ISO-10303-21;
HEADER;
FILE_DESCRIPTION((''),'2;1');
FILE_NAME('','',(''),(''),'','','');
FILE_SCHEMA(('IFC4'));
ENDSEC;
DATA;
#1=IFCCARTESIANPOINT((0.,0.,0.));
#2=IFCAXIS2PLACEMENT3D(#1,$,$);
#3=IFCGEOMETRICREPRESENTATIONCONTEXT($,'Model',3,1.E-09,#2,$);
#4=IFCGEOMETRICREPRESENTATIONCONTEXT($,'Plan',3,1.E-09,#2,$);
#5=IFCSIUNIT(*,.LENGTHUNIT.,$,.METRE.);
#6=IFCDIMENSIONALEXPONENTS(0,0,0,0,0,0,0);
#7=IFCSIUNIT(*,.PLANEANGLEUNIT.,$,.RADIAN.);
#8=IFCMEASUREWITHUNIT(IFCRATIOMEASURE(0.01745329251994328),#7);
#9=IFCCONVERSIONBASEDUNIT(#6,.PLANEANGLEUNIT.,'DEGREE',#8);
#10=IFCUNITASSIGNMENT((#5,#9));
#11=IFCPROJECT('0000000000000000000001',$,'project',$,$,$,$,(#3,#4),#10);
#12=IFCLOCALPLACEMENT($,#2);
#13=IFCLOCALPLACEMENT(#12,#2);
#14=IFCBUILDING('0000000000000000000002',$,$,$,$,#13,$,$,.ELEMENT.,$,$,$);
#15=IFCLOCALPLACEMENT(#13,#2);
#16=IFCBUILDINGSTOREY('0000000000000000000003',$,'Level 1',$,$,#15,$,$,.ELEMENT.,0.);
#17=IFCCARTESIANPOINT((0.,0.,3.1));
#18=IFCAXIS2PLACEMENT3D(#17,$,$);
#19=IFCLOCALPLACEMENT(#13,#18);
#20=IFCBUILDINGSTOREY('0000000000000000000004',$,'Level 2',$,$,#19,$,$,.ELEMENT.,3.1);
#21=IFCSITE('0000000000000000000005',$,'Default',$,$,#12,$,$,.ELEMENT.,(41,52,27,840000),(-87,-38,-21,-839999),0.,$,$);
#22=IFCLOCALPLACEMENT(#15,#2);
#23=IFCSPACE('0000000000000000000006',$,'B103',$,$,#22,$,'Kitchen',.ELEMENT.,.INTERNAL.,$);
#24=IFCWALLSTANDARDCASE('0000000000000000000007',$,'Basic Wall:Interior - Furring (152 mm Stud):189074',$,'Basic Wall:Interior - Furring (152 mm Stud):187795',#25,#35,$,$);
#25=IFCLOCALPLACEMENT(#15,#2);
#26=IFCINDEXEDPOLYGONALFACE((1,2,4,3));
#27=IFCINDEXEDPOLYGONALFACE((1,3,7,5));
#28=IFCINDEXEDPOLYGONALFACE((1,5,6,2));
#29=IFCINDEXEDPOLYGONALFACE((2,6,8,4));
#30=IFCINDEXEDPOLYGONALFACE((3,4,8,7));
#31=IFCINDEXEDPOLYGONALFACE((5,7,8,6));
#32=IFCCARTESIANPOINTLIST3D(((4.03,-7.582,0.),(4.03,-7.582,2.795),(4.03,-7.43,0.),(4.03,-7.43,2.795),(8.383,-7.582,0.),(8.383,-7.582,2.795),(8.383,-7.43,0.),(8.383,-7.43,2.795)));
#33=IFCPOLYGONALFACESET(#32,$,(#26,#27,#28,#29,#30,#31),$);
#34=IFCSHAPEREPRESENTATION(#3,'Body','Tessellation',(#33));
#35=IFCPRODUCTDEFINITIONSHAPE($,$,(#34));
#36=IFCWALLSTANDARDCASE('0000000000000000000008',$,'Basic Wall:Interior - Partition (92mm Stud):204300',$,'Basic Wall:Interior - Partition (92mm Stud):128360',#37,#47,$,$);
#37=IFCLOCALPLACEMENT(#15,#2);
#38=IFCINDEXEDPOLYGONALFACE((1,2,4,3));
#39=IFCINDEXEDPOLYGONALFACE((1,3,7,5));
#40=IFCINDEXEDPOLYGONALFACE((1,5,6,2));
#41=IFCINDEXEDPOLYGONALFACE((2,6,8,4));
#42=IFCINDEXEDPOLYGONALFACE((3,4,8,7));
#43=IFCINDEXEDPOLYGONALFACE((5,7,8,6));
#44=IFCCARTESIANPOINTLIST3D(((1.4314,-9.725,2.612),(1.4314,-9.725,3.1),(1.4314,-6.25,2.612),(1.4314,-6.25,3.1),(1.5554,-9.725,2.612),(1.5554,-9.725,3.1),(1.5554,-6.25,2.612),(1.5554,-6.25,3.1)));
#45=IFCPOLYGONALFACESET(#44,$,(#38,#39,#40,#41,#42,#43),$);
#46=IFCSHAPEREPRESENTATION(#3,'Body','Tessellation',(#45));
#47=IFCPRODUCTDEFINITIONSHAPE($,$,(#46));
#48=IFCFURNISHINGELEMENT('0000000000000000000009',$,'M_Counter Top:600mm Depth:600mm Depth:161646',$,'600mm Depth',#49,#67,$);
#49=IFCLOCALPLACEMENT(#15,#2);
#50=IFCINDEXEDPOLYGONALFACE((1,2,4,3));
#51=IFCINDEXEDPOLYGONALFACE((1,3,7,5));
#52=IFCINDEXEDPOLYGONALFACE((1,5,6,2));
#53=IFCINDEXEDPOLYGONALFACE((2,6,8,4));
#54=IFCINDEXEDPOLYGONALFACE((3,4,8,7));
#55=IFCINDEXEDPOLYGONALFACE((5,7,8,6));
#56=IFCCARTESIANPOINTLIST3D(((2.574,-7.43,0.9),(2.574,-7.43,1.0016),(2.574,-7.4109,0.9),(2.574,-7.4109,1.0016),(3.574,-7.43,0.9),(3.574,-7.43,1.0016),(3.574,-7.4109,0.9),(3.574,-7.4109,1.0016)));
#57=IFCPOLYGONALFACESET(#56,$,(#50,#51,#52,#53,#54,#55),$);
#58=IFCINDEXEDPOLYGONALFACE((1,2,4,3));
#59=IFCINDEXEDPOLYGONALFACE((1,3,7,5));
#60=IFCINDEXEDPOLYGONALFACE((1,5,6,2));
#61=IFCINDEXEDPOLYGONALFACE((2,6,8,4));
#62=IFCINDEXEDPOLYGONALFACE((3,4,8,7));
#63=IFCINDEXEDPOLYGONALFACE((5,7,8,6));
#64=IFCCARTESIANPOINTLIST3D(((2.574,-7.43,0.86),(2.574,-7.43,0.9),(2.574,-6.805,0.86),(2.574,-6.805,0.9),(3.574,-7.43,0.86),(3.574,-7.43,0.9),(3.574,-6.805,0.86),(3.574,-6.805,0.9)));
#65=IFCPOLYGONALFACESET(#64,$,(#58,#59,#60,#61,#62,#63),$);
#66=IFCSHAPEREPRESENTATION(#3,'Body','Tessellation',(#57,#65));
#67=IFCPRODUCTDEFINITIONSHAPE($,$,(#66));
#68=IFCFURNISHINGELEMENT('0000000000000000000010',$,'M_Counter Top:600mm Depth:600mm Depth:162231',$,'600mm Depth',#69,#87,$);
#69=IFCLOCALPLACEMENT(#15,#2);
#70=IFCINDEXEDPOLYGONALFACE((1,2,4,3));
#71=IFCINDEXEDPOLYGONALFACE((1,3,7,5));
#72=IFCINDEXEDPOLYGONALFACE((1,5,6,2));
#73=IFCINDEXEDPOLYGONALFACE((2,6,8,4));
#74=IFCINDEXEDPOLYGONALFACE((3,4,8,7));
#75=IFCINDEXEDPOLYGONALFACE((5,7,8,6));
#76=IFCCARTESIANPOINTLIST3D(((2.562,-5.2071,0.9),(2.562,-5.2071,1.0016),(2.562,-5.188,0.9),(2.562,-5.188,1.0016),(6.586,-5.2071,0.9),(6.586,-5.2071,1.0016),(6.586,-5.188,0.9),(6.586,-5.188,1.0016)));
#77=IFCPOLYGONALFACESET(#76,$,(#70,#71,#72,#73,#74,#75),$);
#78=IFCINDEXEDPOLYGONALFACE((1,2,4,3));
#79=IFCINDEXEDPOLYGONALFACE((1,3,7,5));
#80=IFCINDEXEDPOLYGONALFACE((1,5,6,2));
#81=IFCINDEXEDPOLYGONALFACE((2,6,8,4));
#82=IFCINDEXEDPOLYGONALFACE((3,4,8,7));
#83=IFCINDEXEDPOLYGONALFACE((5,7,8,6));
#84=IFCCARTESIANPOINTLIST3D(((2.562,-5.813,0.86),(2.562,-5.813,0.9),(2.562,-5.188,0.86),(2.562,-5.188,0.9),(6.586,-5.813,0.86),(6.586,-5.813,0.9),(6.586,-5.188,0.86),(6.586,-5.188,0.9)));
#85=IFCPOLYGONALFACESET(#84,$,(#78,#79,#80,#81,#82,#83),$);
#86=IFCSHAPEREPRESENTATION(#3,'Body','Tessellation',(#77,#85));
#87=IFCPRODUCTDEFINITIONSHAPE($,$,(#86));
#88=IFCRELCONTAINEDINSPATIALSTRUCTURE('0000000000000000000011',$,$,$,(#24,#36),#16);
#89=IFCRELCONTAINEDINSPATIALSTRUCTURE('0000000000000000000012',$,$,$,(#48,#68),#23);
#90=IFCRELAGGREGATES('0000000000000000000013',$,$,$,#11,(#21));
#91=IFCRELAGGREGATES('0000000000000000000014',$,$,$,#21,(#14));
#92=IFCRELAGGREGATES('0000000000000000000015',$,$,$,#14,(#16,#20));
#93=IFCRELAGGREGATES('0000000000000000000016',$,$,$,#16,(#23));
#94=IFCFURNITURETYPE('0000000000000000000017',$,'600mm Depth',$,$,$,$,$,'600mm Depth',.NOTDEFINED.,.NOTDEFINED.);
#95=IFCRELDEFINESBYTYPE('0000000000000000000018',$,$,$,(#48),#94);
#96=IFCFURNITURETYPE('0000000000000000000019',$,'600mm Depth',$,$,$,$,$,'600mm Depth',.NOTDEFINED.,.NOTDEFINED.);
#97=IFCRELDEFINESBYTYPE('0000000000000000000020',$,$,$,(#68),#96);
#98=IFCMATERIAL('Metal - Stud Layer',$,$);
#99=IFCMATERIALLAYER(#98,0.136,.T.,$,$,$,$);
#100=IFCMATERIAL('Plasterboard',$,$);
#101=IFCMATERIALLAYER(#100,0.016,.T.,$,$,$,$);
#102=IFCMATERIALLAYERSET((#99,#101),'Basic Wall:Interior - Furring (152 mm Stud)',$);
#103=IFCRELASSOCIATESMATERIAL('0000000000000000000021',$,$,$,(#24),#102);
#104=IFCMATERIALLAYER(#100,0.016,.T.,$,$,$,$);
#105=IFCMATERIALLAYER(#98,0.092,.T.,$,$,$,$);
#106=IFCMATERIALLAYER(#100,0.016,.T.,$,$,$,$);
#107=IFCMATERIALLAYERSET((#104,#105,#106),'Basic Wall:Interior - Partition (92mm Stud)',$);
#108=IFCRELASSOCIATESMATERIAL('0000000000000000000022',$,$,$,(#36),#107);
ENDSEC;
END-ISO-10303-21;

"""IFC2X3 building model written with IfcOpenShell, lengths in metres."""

from ifc_helpers import new_model, entity, si_unit, converted_unit, frame, frame_2d, origin, origin_2d_with_axis, place, context, project, spatial, polyline, rectangle, extrude, clip, bounded_halfspace, source, transform, mapped, material, layer, layer_set, layer_usage, type_object, type_shapes, element, save


model = new_model("IFC2X3")

# Units and contexts
model_context = context("Model", 3, precision=1e-09, world=origin())
plan_context = context("Plan", 3, precision=1e-09, world=origin())
ifc_project = project(units=[si_unit("LENGTHUNIT", "METRE"), converted_unit("PLANEANGLEUNIT", "DEGREE", entity("IfcRatioMeasure", 0.01745329251994328), si_unit("PLANEANGLEUNIT", "RADIAN"), dimensions=[0, 0, 0, 0, 0, 0, 0])], contexts=[model_context, plan_context])

# Site, building, storey
site_placement = place(None, origin())
site = spatial("IfcSite", under=ifc_project, at=site_placement, Name="Default", CompositionType="ELEMENT", RefLatitude=(41, 52, 27, 840000), RefLongitude=(-87, -38, -21, -839999), RefElevation=0.0)
building_placement = place(site_placement, origin())
building = spatial("IfcBuilding", under=site, at=building_placement, CompositionType="ELEMENT")
storey_1_placement = place(building_placement, origin())
storey_1 = spatial("IfcBuildingStorey", under=building, at=storey_1_placement, Name="Level 1", CompositionType="ELEMENT", Elevation=0.0)

# Shared definitions
ifc_material_1 = material(Name="Metal - Stud Layer")
ifc_material_2 = material(Name="Plasterboard")

# Shared definitions
ifc_layer_1 = layer(ifc_material_2, 0.016, ventilated=True)
ifc_layer_2 = layer(ifc_material_1, 0.092, ventilated=True)
ifc_layer_3 = layer(ifc_material_2, 0.016, ventilated=True)
ifc_layer_set_1 = layer_set([ifc_layer_1, ifc_layer_2, ifc_layer_3], Name="Basic Wall:Interior - Partition (92mm Stud)")
ifc_layer_usage_1 = layer_usage(ifc_layer_set_1, "AXIS2", "NEGATIVE", 0.062)

# Shared definitions
ifc_layer_4 = layer(ifc_material_1, 0.136, ventilated=True)
ifc_layer_5 = layer(ifc_material_2, 0.016, ventilated=True)
ifc_layer_set_2 = layer_set([ifc_layer_4, ifc_layer_5], Name="Basic Wall:Interior - Furring (152 mm Stud)")

# Shared definitions
storey_2_placement = place(building_placement, frame((0.0, 0.0, 3.1)))
storey_2 = spatial("IfcBuildingStorey", under=building, at=storey_2_placement, Name="Level 2", CompositionType="ELEMENT", Elevation=3.1)

# Walls
ifc_layer_usage_2 = layer_usage(ifc_layer_set_2, "AXIS2", "NEGATIVE", 0.076)
wall_1_placement = place(storey_1_placement, frame((8.383, -7.506, 0.0), z_axis=(0.0, 0.0, 1.0), x_axis=(-1.0, 0.0, 0.0)))
element("IfcWallStandardCase", 1, at=wall_1_placement, inside=storey_1, material=ifc_layer_usage_2, Name="Basic Wall:Interior - Furring (152 mm Stud):189074", ObjectType="Basic Wall:Interior - Furring (152 mm Stud):187795", context=model_context, shape_type="Clipping", body=[
    clip(extrude(rectangle(XDim=4.353, YDim=0.152, at=frame_2d((2.1765, 0.0), x_axis=(-1.0, 0.0))), origin(), (0.0, 0.0, 1.0), 2.795), bounded_halfspace(frame((0.0, -0.076, 2.795), z_axis=(0.0, 0.0, -1.0), x_axis=(0.0, 1.0, 0.0)), True, frame((0.0, -0.076, 2.795)), polyline([(0.0, 0.0), (3.708, 0.0), (3.708, 0.152), (0.0, 0.152), (0.0, 0.0)]))),
])
wall_2_placement = place(storey_1_placement, frame((1.4934, -6.25, 2.612), z_axis=(0.0, 0.0, 1.0), x_axis=(0.0, -1.0, 0.0)))
element("IfcWallStandardCase", 2, at=wall_2_placement, inside=storey_1, material=ifc_layer_usage_1, Name="Basic Wall:Interior - Partition (92mm Stud):204300", ObjectType="Basic Wall:Interior - Partition (92mm Stud):128360", context=model_context, shape_type="SweptSolid", body=[
    extrude(rectangle(XDim=3.475, YDim=0.124, at=frame_2d((1.7375, 0.0), x_axis=(-1.0, 0.0))), origin(), (0.0, 0.0, 1.0), 0.488),
])

# Shared definitions
space_1_placement = place(storey_1_placement, origin())
space_1 = spatial("IfcSpace", under=storey_1, at=space_1_placement, Name="B103", LongName="Kitchen", CompositionType="ELEMENT", InteriorOrExteriorSpace="INTERNAL")

# Furnishing element
furniture_type_1 = type_object("IfcFurnitureType", Name="600mm Depth", ElementType="600mm Depth", AssemblyPlace="NOTDEFINED")
shared_shape_1 = source(origin(), model_context, "Body", "SweptSolid", [
    extrude(rectangle(XDim=0.0191, YDim=1.0, at=origin_2d_with_axis()), frame((-0.7005, -0.0095, 0.9), z_axis=(0.0, 0.0, 1.0), x_axis=(0.0, -1.0, 0.0)), (0.0, 0.0, 1.0), 0.1016),
    extrude(rectangle(XDim=1.0, YDim=0.625, at=origin_2d_with_axis()), frame((-0.7005, -0.3125, 0.86), z_axis=(0.0, 0.0, 1.0), x_axis=(-1.0, 0.0, 0.0)), (0.0, 0.0, 1.0), 0.04),
])
type_shapes(furniture_type_1, [shared_shape_1])
furnishing_1_placement = place(space_1_placement, frame((2.3735, -7.43, 0.0), z_axis=(0.0, 0.0, 1.0), x_axis=(-1.0, 0.0, 0.0)))
element("IfcFurnishingElement", 3, at=furnishing_1_placement, inside=space_1, type_object=furniture_type_1, Name="M_Counter Top:600mm Depth:600mm Depth:161646", ObjectType="600mm Depth", context=model_context, shape_type="MappedRepresentation", body=[
    mapped(shared_shape_1, transform((0.0, 0.0, 0.0), scale=1.0)),
])

# Furnishing element
furniture_type_2 = type_object("IfcFurnitureType", Name="600mm Depth", ElementType="600mm Depth", AssemblyPlace="NOTDEFINED")
shared_shape_2 = source(origin(), model_context, "Body", "SweptSolid", [
    extrude(rectangle(XDim=0.0191, YDim=4.024, at=origin_2d_with_axis()), frame((0.8115, -0.0095, 0.9), z_axis=(0.0, 0.0, 1.0), x_axis=(0.0, -1.0, 0.0)), (0.0, 0.0, 1.0), 0.1016),
    extrude(rectangle(XDim=4.024, YDim=0.625, at=origin_2d_with_axis()), frame((0.8115, -0.3125, 0.86), z_axis=(0.0, 0.0, 1.0), x_axis=(-1.0, 0.0, 0.0)), (0.0, 0.0, 1.0), 0.04),
])
type_shapes(furniture_type_2, [shared_shape_2])
furnishing_2_placement = place(space_1_placement, frame((3.7625, -5.188, 0.0)))
element("IfcFurnishingElement", 4, at=furnishing_2_placement, inside=space_1, type_object=furniture_type_2, Name="M_Counter Top:600mm Depth:600mm Depth:162231", ObjectType="600mm Depth", context=model_context, shape_type="MappedRepresentation", body=[
    mapped(shared_shape_2, transform((0.0, 0.0, 0.0), scale=1.0)),
])

save(model, "model.ifc")
